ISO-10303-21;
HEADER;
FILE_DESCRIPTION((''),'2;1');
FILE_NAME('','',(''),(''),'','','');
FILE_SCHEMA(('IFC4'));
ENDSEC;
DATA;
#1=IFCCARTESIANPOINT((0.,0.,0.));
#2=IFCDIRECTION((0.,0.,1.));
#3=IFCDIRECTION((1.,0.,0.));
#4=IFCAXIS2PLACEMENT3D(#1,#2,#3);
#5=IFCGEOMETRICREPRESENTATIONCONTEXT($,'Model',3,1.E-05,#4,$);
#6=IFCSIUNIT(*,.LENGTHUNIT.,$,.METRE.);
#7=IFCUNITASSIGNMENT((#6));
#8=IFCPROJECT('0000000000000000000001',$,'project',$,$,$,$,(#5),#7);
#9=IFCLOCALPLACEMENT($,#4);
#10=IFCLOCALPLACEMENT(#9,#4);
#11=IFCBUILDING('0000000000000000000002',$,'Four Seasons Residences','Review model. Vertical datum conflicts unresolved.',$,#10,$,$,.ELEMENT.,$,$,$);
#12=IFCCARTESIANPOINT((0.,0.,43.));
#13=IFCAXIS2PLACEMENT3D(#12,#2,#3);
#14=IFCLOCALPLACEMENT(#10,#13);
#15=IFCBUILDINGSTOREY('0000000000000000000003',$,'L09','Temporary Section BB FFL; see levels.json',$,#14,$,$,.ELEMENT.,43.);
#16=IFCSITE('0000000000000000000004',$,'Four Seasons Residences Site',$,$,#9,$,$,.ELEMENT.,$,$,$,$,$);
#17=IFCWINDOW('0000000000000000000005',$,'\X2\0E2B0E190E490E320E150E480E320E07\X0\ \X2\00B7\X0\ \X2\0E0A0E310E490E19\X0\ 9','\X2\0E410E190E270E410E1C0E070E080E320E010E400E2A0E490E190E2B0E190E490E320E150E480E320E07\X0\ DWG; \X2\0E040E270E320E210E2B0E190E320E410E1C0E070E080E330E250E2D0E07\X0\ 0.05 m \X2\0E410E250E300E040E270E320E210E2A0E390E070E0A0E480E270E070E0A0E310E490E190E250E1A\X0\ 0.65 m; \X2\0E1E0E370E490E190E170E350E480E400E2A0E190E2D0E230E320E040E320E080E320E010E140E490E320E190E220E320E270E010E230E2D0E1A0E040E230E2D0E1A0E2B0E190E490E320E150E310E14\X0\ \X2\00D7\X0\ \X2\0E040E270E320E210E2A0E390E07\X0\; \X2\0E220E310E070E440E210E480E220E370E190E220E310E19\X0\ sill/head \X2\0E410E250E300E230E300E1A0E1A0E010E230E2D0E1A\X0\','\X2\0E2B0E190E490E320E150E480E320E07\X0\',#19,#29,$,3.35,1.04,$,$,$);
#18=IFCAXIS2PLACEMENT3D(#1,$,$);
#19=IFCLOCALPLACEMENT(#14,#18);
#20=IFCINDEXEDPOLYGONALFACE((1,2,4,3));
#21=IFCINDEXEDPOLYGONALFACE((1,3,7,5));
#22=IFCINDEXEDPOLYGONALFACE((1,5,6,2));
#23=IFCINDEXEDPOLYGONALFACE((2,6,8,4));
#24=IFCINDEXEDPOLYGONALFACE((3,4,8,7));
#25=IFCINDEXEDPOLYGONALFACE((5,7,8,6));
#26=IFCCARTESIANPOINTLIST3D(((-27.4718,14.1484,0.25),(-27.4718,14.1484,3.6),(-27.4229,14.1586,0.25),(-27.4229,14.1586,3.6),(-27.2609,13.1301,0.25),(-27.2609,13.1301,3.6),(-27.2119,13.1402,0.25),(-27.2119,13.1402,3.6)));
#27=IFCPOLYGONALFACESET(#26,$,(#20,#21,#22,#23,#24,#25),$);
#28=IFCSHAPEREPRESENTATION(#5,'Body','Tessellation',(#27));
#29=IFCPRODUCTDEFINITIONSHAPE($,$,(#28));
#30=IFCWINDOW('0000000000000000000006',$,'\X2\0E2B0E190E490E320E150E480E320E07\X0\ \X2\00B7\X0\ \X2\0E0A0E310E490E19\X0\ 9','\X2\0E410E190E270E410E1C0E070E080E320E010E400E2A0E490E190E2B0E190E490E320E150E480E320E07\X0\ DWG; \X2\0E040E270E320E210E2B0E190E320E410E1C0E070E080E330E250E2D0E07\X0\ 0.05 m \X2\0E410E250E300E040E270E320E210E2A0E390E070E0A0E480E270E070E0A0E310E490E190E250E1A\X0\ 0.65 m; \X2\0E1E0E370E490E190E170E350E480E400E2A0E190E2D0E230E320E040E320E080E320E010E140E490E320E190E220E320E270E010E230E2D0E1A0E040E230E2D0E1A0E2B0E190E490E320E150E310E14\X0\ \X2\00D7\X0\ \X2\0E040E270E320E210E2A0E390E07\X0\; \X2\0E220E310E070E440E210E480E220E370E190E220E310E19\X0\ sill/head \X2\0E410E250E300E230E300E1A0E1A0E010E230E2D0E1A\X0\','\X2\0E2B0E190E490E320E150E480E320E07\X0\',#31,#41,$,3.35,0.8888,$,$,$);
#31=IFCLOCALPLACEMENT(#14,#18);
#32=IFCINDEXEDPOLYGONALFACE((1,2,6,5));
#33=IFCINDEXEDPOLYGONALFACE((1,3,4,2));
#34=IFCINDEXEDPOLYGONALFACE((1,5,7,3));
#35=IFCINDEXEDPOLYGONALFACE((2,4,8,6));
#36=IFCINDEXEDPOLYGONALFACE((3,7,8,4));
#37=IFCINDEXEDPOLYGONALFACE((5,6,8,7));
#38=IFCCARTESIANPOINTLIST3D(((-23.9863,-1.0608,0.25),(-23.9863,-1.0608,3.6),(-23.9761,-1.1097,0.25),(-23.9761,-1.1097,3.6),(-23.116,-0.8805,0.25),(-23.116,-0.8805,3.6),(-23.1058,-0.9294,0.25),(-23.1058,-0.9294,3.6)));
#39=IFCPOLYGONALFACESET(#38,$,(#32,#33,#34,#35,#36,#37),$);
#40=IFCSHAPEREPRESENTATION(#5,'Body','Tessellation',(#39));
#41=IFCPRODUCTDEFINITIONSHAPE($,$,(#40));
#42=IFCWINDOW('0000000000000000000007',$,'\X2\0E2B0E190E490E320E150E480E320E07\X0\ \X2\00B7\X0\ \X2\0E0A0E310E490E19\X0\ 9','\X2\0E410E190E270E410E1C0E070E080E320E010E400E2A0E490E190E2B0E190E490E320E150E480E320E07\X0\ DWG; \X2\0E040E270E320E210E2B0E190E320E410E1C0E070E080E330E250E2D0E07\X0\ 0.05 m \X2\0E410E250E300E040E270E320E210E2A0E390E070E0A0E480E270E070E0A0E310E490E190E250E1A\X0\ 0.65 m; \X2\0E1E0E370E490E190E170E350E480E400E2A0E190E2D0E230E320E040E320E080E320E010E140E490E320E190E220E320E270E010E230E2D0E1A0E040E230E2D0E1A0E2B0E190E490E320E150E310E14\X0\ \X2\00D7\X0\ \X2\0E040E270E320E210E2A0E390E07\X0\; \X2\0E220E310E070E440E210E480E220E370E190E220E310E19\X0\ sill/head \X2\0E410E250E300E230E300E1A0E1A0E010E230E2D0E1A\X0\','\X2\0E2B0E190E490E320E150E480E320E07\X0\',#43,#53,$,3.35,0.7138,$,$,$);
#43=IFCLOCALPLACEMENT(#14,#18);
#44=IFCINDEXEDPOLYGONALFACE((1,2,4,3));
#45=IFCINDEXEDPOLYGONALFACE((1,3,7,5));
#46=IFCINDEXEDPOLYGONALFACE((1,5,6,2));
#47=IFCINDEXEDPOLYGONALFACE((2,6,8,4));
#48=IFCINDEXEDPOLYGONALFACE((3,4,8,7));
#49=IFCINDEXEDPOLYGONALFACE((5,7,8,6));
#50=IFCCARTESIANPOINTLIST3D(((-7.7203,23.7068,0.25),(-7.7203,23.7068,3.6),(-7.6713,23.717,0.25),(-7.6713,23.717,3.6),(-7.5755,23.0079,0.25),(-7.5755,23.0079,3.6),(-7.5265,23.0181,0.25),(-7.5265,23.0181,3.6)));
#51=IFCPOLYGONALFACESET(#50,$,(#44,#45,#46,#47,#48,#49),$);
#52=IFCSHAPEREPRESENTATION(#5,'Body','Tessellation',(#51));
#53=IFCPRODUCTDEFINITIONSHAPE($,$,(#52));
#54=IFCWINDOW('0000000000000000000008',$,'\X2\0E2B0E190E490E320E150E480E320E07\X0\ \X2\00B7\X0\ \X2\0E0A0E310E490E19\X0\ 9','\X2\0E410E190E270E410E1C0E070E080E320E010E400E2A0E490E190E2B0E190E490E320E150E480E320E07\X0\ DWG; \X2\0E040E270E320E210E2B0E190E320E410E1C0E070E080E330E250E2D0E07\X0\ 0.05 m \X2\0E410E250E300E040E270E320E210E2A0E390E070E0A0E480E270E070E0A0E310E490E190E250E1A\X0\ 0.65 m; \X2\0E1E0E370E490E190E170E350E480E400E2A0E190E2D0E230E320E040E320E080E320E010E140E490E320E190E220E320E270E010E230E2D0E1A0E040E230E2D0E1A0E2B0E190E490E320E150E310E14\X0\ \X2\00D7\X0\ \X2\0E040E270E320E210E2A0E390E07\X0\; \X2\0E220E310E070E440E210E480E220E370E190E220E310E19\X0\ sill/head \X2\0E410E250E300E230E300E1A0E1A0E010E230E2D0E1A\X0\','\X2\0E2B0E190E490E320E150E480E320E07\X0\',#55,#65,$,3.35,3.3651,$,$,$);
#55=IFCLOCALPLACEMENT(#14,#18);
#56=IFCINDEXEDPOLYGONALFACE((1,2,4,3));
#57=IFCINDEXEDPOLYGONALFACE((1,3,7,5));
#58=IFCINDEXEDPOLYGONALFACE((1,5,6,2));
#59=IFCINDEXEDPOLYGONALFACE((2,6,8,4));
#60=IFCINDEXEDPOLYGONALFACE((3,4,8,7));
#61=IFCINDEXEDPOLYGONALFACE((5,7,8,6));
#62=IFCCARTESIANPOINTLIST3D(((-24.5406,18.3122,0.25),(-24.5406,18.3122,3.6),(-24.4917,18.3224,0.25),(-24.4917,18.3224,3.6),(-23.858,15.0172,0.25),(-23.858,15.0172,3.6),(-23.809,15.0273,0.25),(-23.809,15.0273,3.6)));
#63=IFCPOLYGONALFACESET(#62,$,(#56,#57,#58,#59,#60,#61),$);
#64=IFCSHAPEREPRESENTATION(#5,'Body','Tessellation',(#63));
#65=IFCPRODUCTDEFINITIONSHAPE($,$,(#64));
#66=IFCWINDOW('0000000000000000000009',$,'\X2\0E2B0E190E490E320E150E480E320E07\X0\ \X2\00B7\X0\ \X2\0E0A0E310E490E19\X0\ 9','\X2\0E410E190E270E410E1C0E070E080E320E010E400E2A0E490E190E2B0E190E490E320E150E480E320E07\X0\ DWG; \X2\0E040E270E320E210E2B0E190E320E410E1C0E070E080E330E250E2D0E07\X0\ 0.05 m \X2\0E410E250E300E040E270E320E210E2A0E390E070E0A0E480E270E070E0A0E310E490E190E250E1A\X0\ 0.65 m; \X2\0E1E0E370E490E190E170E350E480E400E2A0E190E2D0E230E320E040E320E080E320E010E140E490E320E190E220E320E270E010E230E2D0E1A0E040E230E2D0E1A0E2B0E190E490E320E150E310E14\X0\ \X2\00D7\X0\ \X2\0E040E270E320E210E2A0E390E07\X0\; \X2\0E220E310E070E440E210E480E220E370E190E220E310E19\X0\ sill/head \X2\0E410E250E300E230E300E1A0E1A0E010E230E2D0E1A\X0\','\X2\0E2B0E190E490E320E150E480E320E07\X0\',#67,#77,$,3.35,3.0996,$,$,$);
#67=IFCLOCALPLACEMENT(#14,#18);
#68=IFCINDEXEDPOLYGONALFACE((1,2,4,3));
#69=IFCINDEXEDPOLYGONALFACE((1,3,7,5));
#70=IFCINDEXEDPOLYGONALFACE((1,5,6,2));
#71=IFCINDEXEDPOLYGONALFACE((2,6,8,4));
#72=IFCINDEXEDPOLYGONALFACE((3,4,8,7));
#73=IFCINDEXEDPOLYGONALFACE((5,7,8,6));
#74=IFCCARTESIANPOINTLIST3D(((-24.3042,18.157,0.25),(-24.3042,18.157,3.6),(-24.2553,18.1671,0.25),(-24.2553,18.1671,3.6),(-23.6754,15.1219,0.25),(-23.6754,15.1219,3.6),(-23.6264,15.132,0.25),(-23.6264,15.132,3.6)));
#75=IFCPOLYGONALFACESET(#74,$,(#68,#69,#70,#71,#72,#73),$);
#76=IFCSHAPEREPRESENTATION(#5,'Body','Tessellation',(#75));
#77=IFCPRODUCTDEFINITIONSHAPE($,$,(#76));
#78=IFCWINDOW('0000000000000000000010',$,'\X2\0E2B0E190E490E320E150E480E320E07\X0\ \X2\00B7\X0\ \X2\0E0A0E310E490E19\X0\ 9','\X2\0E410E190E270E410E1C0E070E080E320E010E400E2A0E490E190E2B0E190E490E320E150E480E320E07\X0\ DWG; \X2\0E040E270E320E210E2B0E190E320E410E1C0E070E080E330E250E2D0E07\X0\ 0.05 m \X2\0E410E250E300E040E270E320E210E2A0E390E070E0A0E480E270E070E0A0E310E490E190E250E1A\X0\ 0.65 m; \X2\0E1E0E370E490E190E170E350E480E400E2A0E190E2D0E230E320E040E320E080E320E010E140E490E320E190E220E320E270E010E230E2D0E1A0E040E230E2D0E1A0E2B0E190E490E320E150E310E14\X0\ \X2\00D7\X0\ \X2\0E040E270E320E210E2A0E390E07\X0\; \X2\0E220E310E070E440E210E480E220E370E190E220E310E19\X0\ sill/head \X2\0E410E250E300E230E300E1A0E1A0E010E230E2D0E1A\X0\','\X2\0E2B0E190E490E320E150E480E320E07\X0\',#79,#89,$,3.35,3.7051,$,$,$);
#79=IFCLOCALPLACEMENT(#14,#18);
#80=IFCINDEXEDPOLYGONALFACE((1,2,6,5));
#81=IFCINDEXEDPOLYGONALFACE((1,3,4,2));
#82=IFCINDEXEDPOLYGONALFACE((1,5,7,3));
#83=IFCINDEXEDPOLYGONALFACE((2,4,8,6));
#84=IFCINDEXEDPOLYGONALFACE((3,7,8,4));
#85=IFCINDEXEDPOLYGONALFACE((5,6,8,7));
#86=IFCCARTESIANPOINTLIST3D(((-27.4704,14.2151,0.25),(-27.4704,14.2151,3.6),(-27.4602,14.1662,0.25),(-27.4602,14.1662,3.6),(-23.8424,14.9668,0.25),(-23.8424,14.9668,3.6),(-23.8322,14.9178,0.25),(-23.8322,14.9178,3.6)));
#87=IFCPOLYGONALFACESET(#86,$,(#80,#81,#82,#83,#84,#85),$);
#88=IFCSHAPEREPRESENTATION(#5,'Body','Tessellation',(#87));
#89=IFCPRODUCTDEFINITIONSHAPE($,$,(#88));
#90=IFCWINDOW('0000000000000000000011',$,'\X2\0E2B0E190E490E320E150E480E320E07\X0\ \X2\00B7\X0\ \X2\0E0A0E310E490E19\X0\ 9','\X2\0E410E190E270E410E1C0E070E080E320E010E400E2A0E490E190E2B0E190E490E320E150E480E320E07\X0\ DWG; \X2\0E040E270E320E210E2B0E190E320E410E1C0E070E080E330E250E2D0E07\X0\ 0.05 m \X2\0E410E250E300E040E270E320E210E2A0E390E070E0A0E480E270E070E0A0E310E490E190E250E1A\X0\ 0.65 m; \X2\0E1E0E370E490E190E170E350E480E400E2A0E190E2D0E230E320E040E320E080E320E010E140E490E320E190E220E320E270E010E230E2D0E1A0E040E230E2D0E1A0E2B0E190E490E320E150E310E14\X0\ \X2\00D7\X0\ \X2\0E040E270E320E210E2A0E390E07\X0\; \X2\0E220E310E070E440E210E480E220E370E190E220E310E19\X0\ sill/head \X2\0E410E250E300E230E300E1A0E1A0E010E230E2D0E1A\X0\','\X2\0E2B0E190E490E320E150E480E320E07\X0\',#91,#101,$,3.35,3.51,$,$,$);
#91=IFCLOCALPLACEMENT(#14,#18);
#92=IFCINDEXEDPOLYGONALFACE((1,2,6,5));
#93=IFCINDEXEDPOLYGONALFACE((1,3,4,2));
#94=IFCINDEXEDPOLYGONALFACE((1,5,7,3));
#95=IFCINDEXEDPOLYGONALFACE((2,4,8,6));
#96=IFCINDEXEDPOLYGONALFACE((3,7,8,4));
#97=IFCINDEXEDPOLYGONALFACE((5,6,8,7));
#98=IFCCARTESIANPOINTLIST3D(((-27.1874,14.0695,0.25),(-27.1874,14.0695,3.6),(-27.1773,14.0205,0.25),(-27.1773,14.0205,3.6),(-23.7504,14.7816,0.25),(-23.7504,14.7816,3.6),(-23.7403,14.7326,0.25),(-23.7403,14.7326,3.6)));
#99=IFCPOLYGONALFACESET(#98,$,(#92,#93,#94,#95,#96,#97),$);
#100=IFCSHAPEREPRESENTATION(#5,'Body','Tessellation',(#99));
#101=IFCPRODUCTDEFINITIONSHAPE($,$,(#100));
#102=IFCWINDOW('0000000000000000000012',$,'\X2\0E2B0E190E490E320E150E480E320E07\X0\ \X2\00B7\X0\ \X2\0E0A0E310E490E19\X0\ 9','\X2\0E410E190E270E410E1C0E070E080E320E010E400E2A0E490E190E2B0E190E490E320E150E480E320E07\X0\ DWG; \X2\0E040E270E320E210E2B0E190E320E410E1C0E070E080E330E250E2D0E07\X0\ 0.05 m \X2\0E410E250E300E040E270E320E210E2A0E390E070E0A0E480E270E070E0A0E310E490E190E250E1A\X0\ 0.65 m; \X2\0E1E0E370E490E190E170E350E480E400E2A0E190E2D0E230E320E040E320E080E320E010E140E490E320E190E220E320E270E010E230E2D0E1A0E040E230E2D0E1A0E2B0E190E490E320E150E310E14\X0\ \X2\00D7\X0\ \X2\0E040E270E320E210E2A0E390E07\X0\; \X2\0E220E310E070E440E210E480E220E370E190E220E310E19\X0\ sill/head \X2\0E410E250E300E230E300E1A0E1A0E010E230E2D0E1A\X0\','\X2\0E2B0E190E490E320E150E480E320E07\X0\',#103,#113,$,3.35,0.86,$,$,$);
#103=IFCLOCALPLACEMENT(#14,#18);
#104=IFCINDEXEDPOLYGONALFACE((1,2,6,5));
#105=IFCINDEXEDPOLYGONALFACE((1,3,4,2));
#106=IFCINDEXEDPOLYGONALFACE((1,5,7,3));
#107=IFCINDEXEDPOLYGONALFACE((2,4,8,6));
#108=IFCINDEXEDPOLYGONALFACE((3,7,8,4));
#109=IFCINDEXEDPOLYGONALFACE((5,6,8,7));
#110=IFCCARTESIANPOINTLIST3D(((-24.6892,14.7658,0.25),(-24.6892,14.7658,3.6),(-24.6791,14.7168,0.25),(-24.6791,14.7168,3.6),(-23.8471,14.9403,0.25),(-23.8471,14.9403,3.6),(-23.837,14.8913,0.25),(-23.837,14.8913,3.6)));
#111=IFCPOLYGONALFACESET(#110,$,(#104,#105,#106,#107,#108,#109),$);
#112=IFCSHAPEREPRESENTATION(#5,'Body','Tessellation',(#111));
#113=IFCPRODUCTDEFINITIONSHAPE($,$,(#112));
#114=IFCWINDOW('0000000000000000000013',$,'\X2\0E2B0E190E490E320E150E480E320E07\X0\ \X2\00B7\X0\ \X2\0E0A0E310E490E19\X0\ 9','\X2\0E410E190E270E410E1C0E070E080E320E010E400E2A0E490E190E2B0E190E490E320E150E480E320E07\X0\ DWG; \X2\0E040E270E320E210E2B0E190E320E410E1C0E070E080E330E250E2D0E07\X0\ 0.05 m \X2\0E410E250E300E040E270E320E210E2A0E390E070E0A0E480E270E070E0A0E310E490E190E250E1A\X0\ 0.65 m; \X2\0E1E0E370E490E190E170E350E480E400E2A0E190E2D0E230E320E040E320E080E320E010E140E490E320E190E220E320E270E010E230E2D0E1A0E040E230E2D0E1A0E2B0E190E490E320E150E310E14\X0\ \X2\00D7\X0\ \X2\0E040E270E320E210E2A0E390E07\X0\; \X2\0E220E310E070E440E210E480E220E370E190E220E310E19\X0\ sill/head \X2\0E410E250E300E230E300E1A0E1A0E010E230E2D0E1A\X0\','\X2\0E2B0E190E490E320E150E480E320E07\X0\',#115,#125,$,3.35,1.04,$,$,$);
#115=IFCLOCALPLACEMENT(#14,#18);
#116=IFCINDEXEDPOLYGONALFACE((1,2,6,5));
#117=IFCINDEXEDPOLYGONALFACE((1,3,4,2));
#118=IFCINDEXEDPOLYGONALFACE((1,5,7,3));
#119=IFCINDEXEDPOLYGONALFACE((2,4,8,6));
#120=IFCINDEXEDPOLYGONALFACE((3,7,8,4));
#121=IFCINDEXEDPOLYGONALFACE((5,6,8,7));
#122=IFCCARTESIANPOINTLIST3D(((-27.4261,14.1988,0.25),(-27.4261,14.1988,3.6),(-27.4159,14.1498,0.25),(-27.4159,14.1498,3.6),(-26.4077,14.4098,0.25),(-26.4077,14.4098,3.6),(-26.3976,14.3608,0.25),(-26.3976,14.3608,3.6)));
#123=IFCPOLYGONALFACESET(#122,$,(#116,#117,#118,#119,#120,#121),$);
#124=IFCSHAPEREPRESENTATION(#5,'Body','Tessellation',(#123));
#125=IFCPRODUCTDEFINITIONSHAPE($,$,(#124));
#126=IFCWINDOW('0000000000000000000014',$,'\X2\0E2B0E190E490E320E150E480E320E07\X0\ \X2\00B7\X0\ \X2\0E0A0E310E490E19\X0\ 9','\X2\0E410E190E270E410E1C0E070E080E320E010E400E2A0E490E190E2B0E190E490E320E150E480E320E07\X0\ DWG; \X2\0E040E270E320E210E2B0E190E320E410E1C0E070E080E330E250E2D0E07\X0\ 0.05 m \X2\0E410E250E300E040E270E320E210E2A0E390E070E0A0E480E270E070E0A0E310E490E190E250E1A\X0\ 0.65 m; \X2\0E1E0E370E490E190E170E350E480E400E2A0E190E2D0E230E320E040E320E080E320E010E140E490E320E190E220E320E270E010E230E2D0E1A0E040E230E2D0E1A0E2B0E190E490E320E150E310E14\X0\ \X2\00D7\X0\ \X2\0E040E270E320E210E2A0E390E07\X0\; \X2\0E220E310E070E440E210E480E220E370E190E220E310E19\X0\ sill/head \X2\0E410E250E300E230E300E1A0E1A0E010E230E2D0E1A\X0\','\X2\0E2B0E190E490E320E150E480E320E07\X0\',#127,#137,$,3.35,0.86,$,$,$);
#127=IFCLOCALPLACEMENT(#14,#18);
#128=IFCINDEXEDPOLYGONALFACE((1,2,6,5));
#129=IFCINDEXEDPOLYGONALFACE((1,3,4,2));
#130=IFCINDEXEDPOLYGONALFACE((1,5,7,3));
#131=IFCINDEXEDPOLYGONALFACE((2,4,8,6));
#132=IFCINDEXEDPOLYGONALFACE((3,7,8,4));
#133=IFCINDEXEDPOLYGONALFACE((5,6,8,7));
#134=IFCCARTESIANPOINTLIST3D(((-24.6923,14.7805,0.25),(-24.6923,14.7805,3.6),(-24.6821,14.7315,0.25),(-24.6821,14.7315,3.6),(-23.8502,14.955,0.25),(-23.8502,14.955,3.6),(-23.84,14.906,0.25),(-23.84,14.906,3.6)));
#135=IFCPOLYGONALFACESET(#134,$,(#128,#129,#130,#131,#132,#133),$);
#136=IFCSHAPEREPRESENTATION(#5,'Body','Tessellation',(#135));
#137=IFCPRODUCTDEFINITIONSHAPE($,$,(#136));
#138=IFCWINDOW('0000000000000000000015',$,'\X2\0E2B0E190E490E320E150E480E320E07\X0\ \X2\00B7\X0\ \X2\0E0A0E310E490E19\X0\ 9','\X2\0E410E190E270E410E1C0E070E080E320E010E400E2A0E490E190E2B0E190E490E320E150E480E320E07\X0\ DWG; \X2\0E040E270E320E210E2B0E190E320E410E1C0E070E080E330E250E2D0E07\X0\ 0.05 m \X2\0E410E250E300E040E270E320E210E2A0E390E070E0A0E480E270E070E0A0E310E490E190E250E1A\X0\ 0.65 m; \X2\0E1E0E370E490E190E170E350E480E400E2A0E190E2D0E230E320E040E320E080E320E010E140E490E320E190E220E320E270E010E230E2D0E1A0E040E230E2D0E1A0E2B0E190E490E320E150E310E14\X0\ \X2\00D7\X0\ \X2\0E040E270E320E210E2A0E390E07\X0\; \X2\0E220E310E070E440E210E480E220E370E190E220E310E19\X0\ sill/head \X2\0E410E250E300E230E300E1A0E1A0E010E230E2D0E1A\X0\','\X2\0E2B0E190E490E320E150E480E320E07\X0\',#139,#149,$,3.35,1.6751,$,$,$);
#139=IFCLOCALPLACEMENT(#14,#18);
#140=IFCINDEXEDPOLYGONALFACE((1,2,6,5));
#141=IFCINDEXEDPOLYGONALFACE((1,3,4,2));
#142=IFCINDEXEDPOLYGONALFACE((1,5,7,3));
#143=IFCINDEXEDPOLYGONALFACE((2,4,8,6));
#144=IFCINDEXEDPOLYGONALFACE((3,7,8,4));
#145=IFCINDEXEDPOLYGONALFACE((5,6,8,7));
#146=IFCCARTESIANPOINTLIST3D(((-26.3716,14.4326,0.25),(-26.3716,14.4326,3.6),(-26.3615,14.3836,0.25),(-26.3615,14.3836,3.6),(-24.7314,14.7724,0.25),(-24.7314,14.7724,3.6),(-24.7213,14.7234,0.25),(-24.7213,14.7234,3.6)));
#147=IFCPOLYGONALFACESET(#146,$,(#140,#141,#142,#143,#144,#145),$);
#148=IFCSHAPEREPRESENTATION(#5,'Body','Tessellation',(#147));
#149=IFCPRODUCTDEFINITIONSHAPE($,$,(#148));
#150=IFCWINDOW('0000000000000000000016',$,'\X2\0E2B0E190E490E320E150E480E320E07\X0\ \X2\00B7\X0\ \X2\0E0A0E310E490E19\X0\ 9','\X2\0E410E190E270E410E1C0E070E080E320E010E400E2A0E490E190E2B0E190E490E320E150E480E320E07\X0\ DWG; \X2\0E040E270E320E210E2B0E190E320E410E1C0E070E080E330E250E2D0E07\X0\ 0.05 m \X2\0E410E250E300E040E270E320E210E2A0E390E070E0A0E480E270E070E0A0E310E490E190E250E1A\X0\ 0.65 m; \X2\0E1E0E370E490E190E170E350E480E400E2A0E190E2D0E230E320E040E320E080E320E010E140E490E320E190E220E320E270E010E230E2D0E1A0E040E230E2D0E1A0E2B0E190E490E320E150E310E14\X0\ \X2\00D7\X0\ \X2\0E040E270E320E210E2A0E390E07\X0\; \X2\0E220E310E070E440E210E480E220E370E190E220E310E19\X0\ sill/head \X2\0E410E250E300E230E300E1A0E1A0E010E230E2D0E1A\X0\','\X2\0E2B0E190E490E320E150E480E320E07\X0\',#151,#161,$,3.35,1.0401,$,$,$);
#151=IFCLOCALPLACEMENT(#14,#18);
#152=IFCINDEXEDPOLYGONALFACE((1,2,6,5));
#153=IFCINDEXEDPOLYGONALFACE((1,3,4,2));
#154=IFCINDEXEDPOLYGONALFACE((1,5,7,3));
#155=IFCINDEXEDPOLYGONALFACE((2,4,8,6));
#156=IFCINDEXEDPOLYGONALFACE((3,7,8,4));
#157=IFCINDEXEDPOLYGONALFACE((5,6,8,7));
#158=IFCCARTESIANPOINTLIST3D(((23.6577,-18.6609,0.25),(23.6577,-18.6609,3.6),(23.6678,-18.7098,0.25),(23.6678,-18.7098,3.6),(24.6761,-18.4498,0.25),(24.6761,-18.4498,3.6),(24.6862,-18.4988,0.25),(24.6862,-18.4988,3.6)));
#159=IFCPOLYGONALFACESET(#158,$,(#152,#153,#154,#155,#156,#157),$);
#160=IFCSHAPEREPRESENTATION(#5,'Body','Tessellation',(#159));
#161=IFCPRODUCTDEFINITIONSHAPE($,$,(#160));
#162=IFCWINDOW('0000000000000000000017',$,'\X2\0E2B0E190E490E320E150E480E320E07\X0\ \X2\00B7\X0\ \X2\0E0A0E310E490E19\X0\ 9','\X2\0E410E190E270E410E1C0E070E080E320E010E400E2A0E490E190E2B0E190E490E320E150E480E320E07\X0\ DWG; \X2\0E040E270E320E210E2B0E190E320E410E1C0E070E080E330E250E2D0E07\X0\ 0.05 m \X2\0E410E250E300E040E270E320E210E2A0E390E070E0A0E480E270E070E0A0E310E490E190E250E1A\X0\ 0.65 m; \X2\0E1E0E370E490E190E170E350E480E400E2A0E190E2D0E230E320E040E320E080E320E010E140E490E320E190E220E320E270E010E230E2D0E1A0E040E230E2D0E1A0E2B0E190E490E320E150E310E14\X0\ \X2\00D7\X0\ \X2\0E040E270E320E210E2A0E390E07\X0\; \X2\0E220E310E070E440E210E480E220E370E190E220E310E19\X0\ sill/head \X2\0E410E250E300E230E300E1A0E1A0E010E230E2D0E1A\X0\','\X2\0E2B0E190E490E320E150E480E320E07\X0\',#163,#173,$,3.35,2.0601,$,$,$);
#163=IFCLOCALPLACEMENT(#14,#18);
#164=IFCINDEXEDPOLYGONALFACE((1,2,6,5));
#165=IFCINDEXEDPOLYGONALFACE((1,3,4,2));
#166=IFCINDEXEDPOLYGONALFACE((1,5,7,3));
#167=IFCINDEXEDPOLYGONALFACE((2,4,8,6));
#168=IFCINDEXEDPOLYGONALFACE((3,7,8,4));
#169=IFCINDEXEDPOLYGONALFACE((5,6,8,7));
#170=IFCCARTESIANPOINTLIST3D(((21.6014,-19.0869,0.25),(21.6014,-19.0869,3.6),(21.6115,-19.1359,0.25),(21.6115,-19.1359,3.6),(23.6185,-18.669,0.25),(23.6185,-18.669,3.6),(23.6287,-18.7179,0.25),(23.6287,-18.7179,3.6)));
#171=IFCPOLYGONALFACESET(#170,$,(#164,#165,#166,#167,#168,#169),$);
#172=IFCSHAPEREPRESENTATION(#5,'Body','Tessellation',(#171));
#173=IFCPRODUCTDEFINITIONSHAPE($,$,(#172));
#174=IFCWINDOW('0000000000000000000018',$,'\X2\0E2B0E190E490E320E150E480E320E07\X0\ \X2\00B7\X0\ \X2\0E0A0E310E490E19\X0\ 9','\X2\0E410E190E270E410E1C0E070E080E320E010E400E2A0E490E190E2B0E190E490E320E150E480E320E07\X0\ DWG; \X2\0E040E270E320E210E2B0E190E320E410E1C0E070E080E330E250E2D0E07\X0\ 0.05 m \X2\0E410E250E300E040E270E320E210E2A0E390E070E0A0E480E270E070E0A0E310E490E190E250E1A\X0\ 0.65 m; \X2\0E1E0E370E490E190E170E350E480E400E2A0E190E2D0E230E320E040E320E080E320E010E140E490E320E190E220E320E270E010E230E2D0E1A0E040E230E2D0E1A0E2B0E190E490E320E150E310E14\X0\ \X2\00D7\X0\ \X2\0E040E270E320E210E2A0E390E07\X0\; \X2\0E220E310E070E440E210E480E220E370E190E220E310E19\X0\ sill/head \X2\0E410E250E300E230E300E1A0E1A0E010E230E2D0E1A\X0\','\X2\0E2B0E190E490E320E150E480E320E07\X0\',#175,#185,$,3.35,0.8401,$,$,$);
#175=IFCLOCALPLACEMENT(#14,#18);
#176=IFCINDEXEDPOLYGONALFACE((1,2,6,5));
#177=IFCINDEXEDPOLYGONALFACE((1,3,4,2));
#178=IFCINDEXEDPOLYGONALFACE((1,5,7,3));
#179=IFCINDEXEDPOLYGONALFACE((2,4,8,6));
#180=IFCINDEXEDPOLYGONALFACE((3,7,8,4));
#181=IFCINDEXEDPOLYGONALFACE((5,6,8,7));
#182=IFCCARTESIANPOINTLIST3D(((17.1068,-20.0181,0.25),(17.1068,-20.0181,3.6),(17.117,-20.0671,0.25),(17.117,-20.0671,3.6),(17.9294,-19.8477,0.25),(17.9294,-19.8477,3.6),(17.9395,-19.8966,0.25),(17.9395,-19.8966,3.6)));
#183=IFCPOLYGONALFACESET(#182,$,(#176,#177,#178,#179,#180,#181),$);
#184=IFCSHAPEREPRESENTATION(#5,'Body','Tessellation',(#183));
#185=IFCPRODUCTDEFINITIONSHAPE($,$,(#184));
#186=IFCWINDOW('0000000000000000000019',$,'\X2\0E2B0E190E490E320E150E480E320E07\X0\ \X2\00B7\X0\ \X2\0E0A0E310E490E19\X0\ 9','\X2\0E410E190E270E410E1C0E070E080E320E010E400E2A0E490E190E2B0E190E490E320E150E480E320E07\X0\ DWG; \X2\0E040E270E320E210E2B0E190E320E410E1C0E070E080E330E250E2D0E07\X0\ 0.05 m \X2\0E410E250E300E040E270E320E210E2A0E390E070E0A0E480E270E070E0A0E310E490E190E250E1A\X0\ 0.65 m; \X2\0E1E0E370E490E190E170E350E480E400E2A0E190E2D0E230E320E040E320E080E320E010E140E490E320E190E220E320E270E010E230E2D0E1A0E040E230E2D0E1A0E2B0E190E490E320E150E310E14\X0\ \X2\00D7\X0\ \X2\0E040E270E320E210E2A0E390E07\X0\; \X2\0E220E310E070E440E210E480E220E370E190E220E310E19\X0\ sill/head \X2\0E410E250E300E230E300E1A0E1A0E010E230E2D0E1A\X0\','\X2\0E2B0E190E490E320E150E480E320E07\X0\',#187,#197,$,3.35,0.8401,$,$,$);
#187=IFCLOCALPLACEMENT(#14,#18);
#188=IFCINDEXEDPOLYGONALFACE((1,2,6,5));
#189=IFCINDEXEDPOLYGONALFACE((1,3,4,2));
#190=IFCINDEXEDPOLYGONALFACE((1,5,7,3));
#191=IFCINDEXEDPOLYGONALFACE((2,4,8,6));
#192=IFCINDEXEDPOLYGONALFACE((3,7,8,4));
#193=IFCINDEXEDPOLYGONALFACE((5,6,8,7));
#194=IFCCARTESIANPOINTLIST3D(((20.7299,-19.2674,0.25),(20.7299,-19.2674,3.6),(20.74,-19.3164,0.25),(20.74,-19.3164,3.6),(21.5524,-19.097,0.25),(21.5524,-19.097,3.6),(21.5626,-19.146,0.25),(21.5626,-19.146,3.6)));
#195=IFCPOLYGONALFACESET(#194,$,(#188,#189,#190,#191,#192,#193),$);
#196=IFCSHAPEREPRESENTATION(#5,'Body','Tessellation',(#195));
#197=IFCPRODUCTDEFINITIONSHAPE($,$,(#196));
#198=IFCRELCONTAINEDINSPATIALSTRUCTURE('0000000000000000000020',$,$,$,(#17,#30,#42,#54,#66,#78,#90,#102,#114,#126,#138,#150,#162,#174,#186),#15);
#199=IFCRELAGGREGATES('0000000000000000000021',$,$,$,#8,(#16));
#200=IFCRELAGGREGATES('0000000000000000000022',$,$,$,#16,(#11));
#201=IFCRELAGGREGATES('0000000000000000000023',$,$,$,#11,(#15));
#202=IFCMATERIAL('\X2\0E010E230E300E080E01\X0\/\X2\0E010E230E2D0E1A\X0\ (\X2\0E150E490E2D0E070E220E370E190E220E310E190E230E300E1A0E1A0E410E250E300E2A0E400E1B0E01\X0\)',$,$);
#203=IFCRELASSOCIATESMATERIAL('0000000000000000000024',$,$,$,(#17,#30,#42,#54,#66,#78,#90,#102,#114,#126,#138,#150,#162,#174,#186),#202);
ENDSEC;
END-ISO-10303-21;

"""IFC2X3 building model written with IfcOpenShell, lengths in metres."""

from ifc_helpers import new_model, si_unit, frame, origin_with_axes, place, context, project, spatial, polyline, outline, extrude, material, element, save


model = new_model("IFC2X3")

# Units and contexts
model_context = context("Model", 3, precision=1e-05, world=origin_with_axes())
ifc_project = project(units=[si_unit("LENGTHUNIT", "METRE")], contexts=[model_context])

# Site, building, storey
site_placement = place(None, origin_with_axes())
site = spatial("IfcSite", under=ifc_project, at=site_placement, Name="Four Seasons Residences Site", CompositionType="ELEMENT")
building_placement = place(site_placement, origin_with_axes())
building = spatial("IfcBuilding", under=site, at=building_placement, Name="Four Seasons Residences", Description="Review model. Vertical datum conflicts unresolved.", CompositionType="ELEMENT")
storey_placement = place(building_placement, frame((0.0, 0.0, 43.0), z_axis=(0.0, 0.0, 1.0), x_axis=(1.0, 0.0, 0.0)))
storey = spatial("IfcBuildingStorey", under=building, at=storey_placement, Name="L09", Description="Temporary Section BB FFL; see levels.json", CompositionType="ELEMENT", Elevation=43.0)

# Windows
ifc_material_1 = material(Name="กระจก/กรอบ (ต้องยืนยันระบบและสเปก)")
window_1_placement = place(storey_placement, origin_with_axes())
element("IfcWindow", 1, at=window_1_placement, inside=storey, material=ifc_material_1, Name="หน้าต่าง · ชั้น 9", Description="แนวแผงจากเส้นหน้าต่าง DWG; ความหนาแผงจำลอง 0.05 m และความสูงช่วงชั้นลบ 0.65 m; พื้นที่เสนอราคาจากด้านยาวกรอบครอบหน้าตัด × ความสูง; ยังไม่ยืนยัน sill/head และระบบกรอบ", ObjectType="หน้าต่าง", OverallHeight=3.35, OverallWidth=1.04, context=model_context, shape_type="SweptSolid", body=[
    extrude(outline(polyline([(-27.4718, 14.1484), (-27.4229, 14.1586), (-27.2119, 13.1402), (-27.2609, 13.1301), (-27.4718, 14.1484)])), frame((0.0, 0.0, 0.25), z_axis=(0.0, 0.0, 1.0), x_axis=(1.0, 0.0, 0.0)), (0.0, 0.0, 1.0), 3.35),
])
window_2_placement = place(storey_placement, origin_with_axes())
element("IfcWindow", 2, at=window_2_placement, inside=storey, material=ifc_material_1, Name="หน้าต่าง · ชั้น 9", Description="แนวแผงจากเส้นหน้าต่าง DWG; ความหนาแผงจำลอง 0.05 m และความสูงช่วงชั้นลบ 0.65 m; พื้นที่เสนอราคาจากด้านยาวกรอบครอบหน้าตัด × ความสูง; ยังไม่ยืนยัน sill/head และระบบกรอบ", ObjectType="หน้าต่าง", OverallHeight=3.35, OverallWidth=0.8888, context=model_context, shape_type="SweptSolid", body=[
    extrude(outline(polyline([(-23.9761, -1.1097), (-23.9863, -1.0608), (-23.116, -0.8805), (-23.1058, -0.9294), (-23.9761, -1.1097)])), frame((0.0, 0.0, 0.25), z_axis=(0.0, 0.0, 1.0), x_axis=(1.0, 0.0, 0.0)), (0.0, 0.0, 1.0), 3.35),
])
window_3_placement = place(storey_placement, origin_with_axes())
element("IfcWindow", 3, at=window_3_placement, inside=storey, material=ifc_material_1, Name="หน้าต่าง · ชั้น 9", Description="แนวแผงจากเส้นหน้าต่าง DWG; ความหนาแผงจำลอง 0.05 m และความสูงช่วงชั้นลบ 0.65 m; พื้นที่เสนอราคาจากด้านยาวกรอบครอบหน้าตัด × ความสูง; ยังไม่ยืนยัน sill/head และระบบกรอบ", ObjectType="หน้าต่าง", OverallHeight=3.35, OverallWidth=0.7138, context=model_context, shape_type="SweptSolid", body=[
    extrude(outline(polyline([(-7.7203, 23.7068), (-7.6713, 23.717), (-7.5265, 23.0181), (-7.5755, 23.0079), (-7.7203, 23.7068)])), frame((0.0, 0.0, 0.25), z_axis=(0.0, 0.0, 1.0), x_axis=(1.0, 0.0, 0.0)), (0.0, 0.0, 1.0), 3.35),
])
window_4_placement = place(storey_placement, origin_with_axes())
element("IfcWindow", 4, at=window_4_placement, inside=storey, material=ifc_material_1, Name="หน้าต่าง · ชั้น 9", Description="แนวแผงจากเส้นหน้าต่าง DWG; ความหนาแผงจำลอง 0.05 m และความสูงช่วงชั้นลบ 0.65 m; พื้นที่เสนอราคาจากด้านยาวกรอบครอบหน้าตัด × ความสูง; ยังไม่ยืนยัน sill/head และระบบกรอบ", ObjectType="หน้าต่าง", OverallHeight=3.35, OverallWidth=3.3651, context=model_context, shape_type="SweptSolid", body=[
    extrude(outline(polyline([(-24.5406, 18.3122), (-24.4917, 18.3224), (-23.809, 15.0273), (-23.858, 15.0172), (-24.5406, 18.3122)])), frame((0.0, 0.0, 0.25), z_axis=(0.0, 0.0, 1.0), x_axis=(1.0, 0.0, 0.0)), (0.0, 0.0, 1.0), 3.35),
])
window_5_placement = place(storey_placement, origin_with_axes())
element("IfcWindow", 5, at=window_5_placement, inside=storey, material=ifc_material_1, Name="หน้าต่าง · ชั้น 9", Description="แนวแผงจากเส้นหน้าต่าง DWG; ความหนาแผงจำลอง 0.05 m และความสูงช่วงชั้นลบ 0.65 m; พื้นที่เสนอราคาจากด้านยาวกรอบครอบหน้าตัด × ความสูง; ยังไม่ยืนยัน sill/head และระบบกรอบ", ObjectType="หน้าต่าง", OverallHeight=3.35, OverallWidth=3.0996, context=model_context, shape_type="SweptSolid", body=[
    extrude(outline(polyline([(-23.6264, 15.132), (-23.6754, 15.1219), (-24.3042, 18.157), (-24.2553, 18.1671), (-23.6264, 15.132)])), frame((0.0, 0.0, 0.25), z_axis=(0.0, 0.0, 1.0), x_axis=(1.0, 0.0, 0.0)), (0.0, 0.0, 1.0), 3.35),
])
window_6_placement = place(storey_placement, origin_with_axes())
element("IfcWindow", 6, at=window_6_placement, inside=storey, material=ifc_material_1, Name="หน้าต่าง · ชั้น 9", Description="แนวแผงจากเส้นหน้าต่าง DWG; ความหนาแผงจำลอง 0.05 m และความสูงช่วงชั้นลบ 0.65 m; พื้นที่เสนอราคาจากด้านยาวกรอบครอบหน้าตัด × ความสูง; ยังไม่ยืนยัน sill/head และระบบกรอบ", ObjectType="หน้าต่าง", OverallHeight=3.35, OverallWidth=3.7051, context=model_context, shape_type="SweptSolid", body=[
    extrude(outline(polyline([(-23.8424, 14.9668), (-23.8322, 14.9178), (-27.4602, 14.1662), (-27.4704, 14.2151), (-23.8424, 14.9668)])), frame((0.0, 0.0, 0.25), z_axis=(0.0, 0.0, 1.0), x_axis=(1.0, 0.0, 0.0)), (0.0, 0.0, 1.0), 3.35),
])
window_7_placement = place(storey_placement, origin_with_axes())
element("IfcWindow", 7, at=window_7_placement, inside=storey, material=ifc_material_1, Name="หน้าต่าง · ชั้น 9", Description="แนวแผงจากเส้นหน้าต่าง DWG; ความหนาแผงจำลอง 0.05 m และความสูงช่วงชั้นลบ 0.65 m; พื้นที่เสนอราคาจากด้านยาวกรอบครอบหน้าตัด × ความสูง; ยังไม่ยืนยัน sill/head และระบบกรอบ", ObjectType="หน้าต่าง", OverallHeight=3.35, OverallWidth=3.51, context=model_context, shape_type="SweptSolid", body=[
    extrude(outline(polyline([(-23.7504, 14.7816), (-23.7403, 14.7326), (-27.1773, 14.0205), (-27.1874, 14.0695), (-23.7504, 14.7816)])), frame((0.0, 0.0, 0.25), z_axis=(0.0, 0.0, 1.0), x_axis=(1.0, 0.0, 0.0)), (0.0, 0.0, 1.0), 3.35),
])
window_8_placement = place(storey_placement, origin_with_axes())
element("IfcWindow", 8, at=window_8_placement, inside=storey, material=ifc_material_1, Name="หน้าต่าง · ชั้น 9", Description="แนวแผงจากเส้นหน้าต่าง DWG; ความหนาแผงจำลอง 0.05 m และความสูงช่วงชั้นลบ 0.65 m; พื้นที่เสนอราคาจากด้านยาวกรอบครอบหน้าตัด × ความสูง; ยังไม่ยืนยัน sill/head และระบบกรอบ", ObjectType="หน้าต่าง", OverallHeight=3.35, OverallWidth=0.86, context=model_context, shape_type="SweptSolid", body=[
    extrude(outline(polyline([(-24.6791, 14.7168), (-24.6892, 14.7658), (-23.8471, 14.9403), (-23.837, 14.8913), (-24.6791, 14.7168)])), frame((0.0, 0.0, 0.25), z_axis=(0.0, 0.0, 1.0), x_axis=(1.0, 0.0, 0.0)), (0.0, 0.0, 1.0), 3.35),
])
window_9_placement = place(storey_placement, origin_with_axes())
element("IfcWindow", 9, at=window_9_placement, inside=storey, material=ifc_material_1, Name="หน้าต่าง · ชั้น 9", Description="แนวแผงจากเส้นหน้าต่าง DWG; ความหนาแผงจำลอง 0.05 m และความสูงช่วงชั้นลบ 0.65 m; พื้นที่เสนอราคาจากด้านยาวกรอบครอบหน้าตัด × ความสูง; ยังไม่ยืนยัน sill/head และระบบกรอบ", ObjectType="หน้าต่าง", OverallHeight=3.35, OverallWidth=1.04, context=model_context, shape_type="SweptSolid", body=[
    extrude(outline(polyline([(-27.4159, 14.1498), (-27.4261, 14.1988), (-26.4077, 14.4098), (-26.3976, 14.3608), (-27.4159, 14.1498)])), frame((0.0, 0.0, 0.25), z_axis=(0.0, 0.0, 1.0), x_axis=(1.0, 0.0, 0.0)), (0.0, 0.0, 1.0), 3.35),
])
window_10_placement = place(storey_placement, origin_with_axes())
element("IfcWindow", 10, at=window_10_placement, inside=storey, material=ifc_material_1, Name="หน้าต่าง · ชั้น 9", Description="แนวแผงจากเส้นหน้าต่าง DWG; ความหนาแผงจำลอง 0.05 m และความสูงช่วงชั้นลบ 0.65 m; พื้นที่เสนอราคาจากด้านยาวกรอบครอบหน้าตัด × ความสูง; ยังไม่ยืนยัน sill/head และระบบกรอบ", ObjectType="หน้าต่าง", OverallHeight=3.35, OverallWidth=0.86, context=model_context, shape_type="SweptSolid", body=[
    extrude(outline(polyline([(-24.6821, 14.7315), (-24.6923, 14.7805), (-23.8502, 14.955), (-23.84, 14.906), (-24.6821, 14.7315)])), frame((0.0, 0.0, 0.25), z_axis=(0.0, 0.0, 1.0), x_axis=(1.0, 0.0, 0.0)), (0.0, 0.0, 1.0), 3.35),
])
window_11_placement = place(storey_placement, origin_with_axes())
element("IfcWindow", 11, at=window_11_placement, inside=storey, material=ifc_material_1, Name="หน้าต่าง · ชั้น 9", Description="แนวแผงจากเส้นหน้าต่าง DWG; ความหนาแผงจำลอง 0.05 m และความสูงช่วงชั้นลบ 0.65 m; พื้นที่เสนอราคาจากด้านยาวกรอบครอบหน้าตัด × ความสูง; ยังไม่ยืนยัน sill/head และระบบกรอบ", ObjectType="หน้าต่าง", OverallHeight=3.35, OverallWidth=1.6751, context=model_context, shape_type="SweptSolid", body=[
    extrude(outline(polyline([(-26.3615, 14.3836), (-26.3716, 14.4326), (-24.7314, 14.7724), (-24.7213, 14.7234), (-26.3615, 14.3836)])), frame((0.0, 0.0, 0.25), z_axis=(0.0, 0.0, 1.0), x_axis=(1.0, 0.0, 0.0)), (0.0, 0.0, 1.0), 3.35),
])
window_12_placement = place(storey_placement, origin_with_axes())
element("IfcWindow", 12, at=window_12_placement, inside=storey, material=ifc_material_1, Name="หน้าต่าง · ชั้น 9", Description="แนวแผงจากเส้นหน้าต่าง DWG; ความหนาแผงจำลอง 0.05 m และความสูงช่วงชั้นลบ 0.65 m; พื้นที่เสนอราคาจากด้านยาวกรอบครอบหน้าตัด × ความสูง; ยังไม่ยืนยัน sill/head และระบบกรอบ", ObjectType="หน้าต่าง", OverallHeight=3.35, OverallWidth=1.0401, context=model_context, shape_type="SweptSolid", body=[
    extrude(outline(polyline([(23.6678, -18.7098), (23.6577, -18.6609), (24.6761, -18.4498), (24.6862, -18.4988), (23.6678, -18.7098)])), frame((0.0, 0.0, 0.25), z_axis=(0.0, 0.0, 1.0), x_axis=(1.0, 0.0, 0.0)), (0.0, 0.0, 1.0), 3.35),
])
window_13_placement = place(storey_placement, origin_with_axes())
element("IfcWindow", 13, at=window_13_placement, inside=storey, material=ifc_material_1, Name="หน้าต่าง · ชั้น 9", Description="แนวแผงจากเส้นหน้าต่าง DWG; ความหนาแผงจำลอง 0.05 m และความสูงช่วงชั้นลบ 0.65 m; พื้นที่เสนอราคาจากด้านยาวกรอบครอบหน้าตัด × ความสูง; ยังไม่ยืนยัน sill/head และระบบกรอบ", ObjectType="หน้าต่าง", OverallHeight=3.35, OverallWidth=2.0601, context=model_context, shape_type="SweptSolid", body=[
    extrude(outline(polyline([(21.6115, -19.1359), (21.6014, -19.0869), (23.6185, -18.669), (23.6287, -18.7179), (21.6115, -19.1359)])), frame((0.0, 0.0, 0.25), z_axis=(0.0, 0.0, 1.0), x_axis=(1.0, 0.0, 0.0)), (0.0, 0.0, 1.0), 3.35),
])
window_14_placement = place(storey_placement, origin_with_axes())
element("IfcWindow", 14, at=window_14_placement, inside=storey, material=ifc_material_1, Name="หน้าต่าง · ชั้น 9", Description="แนวแผงจากเส้นหน้าต่าง DWG; ความหนาแผงจำลอง 0.05 m และความสูงช่วงชั้นลบ 0.65 m; พื้นที่เสนอราคาจากด้านยาวกรอบครอบหน้าตัด × ความสูง; ยังไม่ยืนยัน sill/head และระบบกรอบ", ObjectType="หน้าต่าง", OverallHeight=3.35, OverallWidth=0.8401, context=model_context, shape_type="SweptSolid", body=[
    extrude(outline(polyline([(17.117, -20.0671), (17.1068, -20.0181), (17.9294, -19.8477), (17.9395, -19.8966), (17.117, -20.0671)])), frame((0.0, 0.0, 0.25), z_axis=(0.0, 0.0, 1.0), x_axis=(1.0, 0.0, 0.0)), (0.0, 0.0, 1.0), 3.35),
])
window_15_placement = place(storey_placement, origin_with_axes())
element("IfcWindow", 15, at=window_15_placement, inside=storey, material=ifc_material_1, Name="หน้าต่าง · ชั้น 9", Description="แนวแผงจากเส้นหน้าต่าง DWG; ความหนาแผงจำลอง 0.05 m และความสูงช่วงชั้นลบ 0.65 m; พื้นที่เสนอราคาจากด้านยาวกรอบครอบหน้าตัด × ความสูง; ยังไม่ยืนยัน sill/head และระบบกรอบ", ObjectType="หน้าต่าง", OverallHeight=3.35, OverallWidth=0.8401, context=model_context, shape_type="SweptSolid", body=[
    extrude(outline(polyline([(21.5524, -19.097), (21.5626, -19.146), (20.74, -19.3164), (20.7299, -19.2674), (21.5524, -19.097)])), frame((0.0, 0.0, 0.25), z_axis=(0.0, 0.0, 1.0), x_axis=(1.0, 0.0, 0.0)), (0.0, 0.0, 1.0), 3.35),
])

save(model, "model.ifc")
